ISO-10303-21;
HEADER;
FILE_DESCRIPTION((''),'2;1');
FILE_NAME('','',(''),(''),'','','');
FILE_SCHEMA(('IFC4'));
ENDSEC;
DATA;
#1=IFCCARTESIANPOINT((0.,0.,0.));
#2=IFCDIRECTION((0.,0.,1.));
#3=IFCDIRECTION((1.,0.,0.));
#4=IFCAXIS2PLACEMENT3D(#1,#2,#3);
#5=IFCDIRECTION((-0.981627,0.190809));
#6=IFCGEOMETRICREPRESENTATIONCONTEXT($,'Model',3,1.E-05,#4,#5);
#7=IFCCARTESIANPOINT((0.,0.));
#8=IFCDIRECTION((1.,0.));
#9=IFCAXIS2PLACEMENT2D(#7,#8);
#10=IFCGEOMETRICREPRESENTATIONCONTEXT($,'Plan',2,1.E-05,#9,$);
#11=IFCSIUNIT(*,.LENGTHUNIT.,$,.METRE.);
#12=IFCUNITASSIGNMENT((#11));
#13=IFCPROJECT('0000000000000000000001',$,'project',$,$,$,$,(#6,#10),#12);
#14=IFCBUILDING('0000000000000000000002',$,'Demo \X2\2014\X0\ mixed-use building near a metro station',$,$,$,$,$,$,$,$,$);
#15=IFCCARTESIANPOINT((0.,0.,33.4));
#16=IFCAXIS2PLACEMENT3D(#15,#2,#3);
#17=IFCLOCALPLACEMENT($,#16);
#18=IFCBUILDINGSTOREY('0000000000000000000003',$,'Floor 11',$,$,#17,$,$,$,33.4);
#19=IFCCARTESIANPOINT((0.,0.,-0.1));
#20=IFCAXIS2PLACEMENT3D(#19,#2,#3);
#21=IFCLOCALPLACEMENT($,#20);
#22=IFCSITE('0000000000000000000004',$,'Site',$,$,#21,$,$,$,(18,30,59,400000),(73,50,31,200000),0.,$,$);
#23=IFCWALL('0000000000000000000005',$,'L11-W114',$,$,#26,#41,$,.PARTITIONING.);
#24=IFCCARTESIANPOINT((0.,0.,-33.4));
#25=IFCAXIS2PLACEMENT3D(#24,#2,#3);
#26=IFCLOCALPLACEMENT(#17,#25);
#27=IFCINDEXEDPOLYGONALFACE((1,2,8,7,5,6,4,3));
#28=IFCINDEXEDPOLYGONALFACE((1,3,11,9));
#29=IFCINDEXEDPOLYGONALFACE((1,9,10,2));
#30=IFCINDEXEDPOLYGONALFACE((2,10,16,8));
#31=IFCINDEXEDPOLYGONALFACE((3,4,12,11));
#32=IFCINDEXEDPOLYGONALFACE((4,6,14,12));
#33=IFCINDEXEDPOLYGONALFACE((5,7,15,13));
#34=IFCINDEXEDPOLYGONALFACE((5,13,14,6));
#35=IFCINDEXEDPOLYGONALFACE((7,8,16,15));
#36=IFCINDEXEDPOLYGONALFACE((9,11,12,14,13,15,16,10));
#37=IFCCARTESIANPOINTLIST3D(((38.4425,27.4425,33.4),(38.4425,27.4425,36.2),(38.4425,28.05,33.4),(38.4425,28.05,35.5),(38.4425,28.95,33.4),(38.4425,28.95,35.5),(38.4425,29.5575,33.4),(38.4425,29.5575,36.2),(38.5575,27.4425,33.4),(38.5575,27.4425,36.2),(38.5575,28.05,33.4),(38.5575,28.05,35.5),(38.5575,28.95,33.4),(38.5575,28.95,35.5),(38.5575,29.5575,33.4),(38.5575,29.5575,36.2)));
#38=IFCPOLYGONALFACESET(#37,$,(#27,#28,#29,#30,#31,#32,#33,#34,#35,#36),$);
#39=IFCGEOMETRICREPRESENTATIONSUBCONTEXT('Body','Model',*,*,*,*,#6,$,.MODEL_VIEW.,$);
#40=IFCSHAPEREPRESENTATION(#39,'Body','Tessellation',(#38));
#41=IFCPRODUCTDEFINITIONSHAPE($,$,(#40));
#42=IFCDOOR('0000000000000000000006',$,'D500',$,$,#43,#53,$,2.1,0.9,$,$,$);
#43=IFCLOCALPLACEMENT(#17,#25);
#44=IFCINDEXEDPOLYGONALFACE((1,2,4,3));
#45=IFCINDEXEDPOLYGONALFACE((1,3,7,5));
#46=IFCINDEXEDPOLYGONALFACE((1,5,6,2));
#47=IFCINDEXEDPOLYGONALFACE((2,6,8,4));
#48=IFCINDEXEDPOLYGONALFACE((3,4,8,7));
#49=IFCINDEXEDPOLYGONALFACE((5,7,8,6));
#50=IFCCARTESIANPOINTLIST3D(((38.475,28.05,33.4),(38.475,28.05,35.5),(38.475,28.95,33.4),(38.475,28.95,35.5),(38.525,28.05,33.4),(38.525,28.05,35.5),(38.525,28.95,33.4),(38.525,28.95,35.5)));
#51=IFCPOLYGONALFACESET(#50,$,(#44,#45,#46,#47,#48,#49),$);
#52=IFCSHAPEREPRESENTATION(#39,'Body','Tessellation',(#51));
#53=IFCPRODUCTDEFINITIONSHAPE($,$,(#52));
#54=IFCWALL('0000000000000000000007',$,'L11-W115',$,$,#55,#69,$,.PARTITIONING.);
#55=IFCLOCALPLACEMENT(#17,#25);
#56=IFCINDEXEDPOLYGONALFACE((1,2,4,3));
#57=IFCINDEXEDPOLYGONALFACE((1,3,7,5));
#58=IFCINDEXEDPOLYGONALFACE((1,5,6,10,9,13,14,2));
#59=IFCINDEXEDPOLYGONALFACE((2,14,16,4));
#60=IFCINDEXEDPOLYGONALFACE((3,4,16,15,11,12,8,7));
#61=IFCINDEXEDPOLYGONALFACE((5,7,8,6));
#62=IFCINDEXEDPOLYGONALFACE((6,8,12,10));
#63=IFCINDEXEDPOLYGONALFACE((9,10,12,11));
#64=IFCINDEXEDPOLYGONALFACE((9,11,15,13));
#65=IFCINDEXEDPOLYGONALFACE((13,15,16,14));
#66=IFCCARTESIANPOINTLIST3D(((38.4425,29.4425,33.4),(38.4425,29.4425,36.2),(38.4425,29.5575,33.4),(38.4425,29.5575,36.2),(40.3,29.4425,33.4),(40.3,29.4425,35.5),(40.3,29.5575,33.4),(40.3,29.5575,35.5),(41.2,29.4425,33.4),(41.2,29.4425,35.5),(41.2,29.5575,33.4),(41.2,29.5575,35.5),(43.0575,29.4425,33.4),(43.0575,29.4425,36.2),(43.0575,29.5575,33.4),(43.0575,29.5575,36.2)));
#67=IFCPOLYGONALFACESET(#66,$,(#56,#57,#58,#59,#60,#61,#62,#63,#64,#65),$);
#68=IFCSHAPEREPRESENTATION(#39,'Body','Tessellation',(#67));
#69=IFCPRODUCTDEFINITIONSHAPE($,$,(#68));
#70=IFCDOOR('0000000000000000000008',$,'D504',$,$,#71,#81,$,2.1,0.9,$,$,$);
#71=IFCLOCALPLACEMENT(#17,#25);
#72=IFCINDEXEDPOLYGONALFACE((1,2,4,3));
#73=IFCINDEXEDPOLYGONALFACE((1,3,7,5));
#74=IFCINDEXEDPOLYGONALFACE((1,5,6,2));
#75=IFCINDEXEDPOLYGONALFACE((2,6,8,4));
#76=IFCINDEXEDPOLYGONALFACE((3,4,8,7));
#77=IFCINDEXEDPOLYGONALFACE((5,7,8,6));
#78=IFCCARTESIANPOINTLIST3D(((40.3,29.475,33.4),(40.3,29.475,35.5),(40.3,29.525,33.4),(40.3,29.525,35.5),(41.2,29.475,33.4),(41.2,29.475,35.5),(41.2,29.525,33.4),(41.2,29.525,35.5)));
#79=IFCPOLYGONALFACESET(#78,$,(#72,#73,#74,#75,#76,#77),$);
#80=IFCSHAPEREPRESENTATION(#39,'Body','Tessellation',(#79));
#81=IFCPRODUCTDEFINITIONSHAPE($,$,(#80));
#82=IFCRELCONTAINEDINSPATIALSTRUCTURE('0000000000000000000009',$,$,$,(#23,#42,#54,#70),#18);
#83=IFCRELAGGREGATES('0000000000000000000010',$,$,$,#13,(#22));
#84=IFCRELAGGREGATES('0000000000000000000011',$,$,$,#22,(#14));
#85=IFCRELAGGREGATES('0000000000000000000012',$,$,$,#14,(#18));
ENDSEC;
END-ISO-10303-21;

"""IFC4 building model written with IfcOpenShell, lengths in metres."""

from ifc_helpers import new_model, si_unit, direction, frame, origin_with_axes, origin_2d_with_axis, place, context, subcontext, project, spatial, line, indexed_curve, outline, extrude, element, fill, save


model = new_model("IFC4")

# Units and contexts
model_context = context("Model", 3, precision=1e-05, world=origin_with_axes(), true_north=direction((-0.981627, 0.190809)))
plan_context = context("Plan", 2, precision=1e-05, world=origin_2d_with_axis())
body_context = subcontext(model_context, "Body", "Model", "MODEL_VIEW")
ifc_project = project(units=[si_unit("LENGTHUNIT", "METRE")], contexts=[model_context, plan_context])

# Site, building, storey
site_placement = place(None, frame((0.0, 0.0, -0.1), z_axis=(0.0, 0.0, 1.0), x_axis=(1.0, 0.0, 0.0)))
site = spatial("IfcSite", under=ifc_project, at=site_placement, Name="Site", RefLatitude=(18, 30, 59, 400000), RefLongitude=(73, 50, 31, 200000), RefElevation=0.0)
building = spatial("IfcBuilding", under=site, Name="Demo — mixed-use building near a metro station")
storey_placement = place(None, frame((0.0, 0.0, 33.4), z_axis=(0.0, 0.0, 1.0), x_axis=(1.0, 0.0, 0.0)))
storey = spatial("IfcBuildingStorey", under=building, at=storey_placement, Name="Floor 11", Elevation=33.4)

# Walls, openings, doors
wall_1_placement = place(storey_placement, frame((0.0, 0.0, -33.4), z_axis=(0.0, 0.0, 1.0), x_axis=(1.0, 0.0, 0.0)))
wall_1 = element("IfcWall", 1, at=wall_1_placement, inside=storey, Name="L11-W114", PredefinedType="PARTITIONING", context=body_context, shape_type="SweptSolid", body=[
    extrude(outline(indexed_curve([(38.5575, 29.5575), (38.5575, 27.4425), (38.4425, 27.4425), (38.4425, 29.5575)], segments=[line(1, 2, 3, 4, 1)])), frame((0.0, 0.0, 33.4), z_axis=(0.0, 0.0, 1.0), x_axis=(1.0, 0.0, 0.0)), (0.0, 0.0, 1.0), 2.8),
])
opening_1_placement = place(wall_1_placement, origin_with_axes())
opening_1 = element("IfcOpeningElement", 2, at=opening_1_placement, cuts=wall_1, context=body_context, shape_type="SweptSolid", body=[
    extrude(outline(indexed_curve([(38.6075, 28.95), (38.6075, 28.05), (38.3925, 28.05), (38.3925, 28.95)], segments=[line(1, 2, 3, 4, 1)])), frame((0.0, 0.0, 33.4), z_axis=(0.0, 0.0, 1.0), x_axis=(1.0, 0.0, 0.0)), (0.0, 0.0, 1.0), 2.1),
])
door_1_placement = place(storey_placement, frame((0.0, 0.0, -33.4), z_axis=(0.0, 0.0, 1.0), x_axis=(1.0, 0.0, 0.0)))
door_1 = element("IfcDoor", 3, at=door_1_placement, inside=storey, Name="D500", OverallHeight=2.1, OverallWidth=0.9, context=body_context, shape_type="SweptSolid", body=[
    extrude(outline(indexed_curve([(38.525, 28.95), (38.525, 28.05), (38.475, 28.05), (38.475, 28.95)], segments=[line(1, 2, 3, 4, 1)])), frame((0.0, 0.0, 33.4), z_axis=(0.0, 0.0, 1.0), x_axis=(1.0, 0.0, 0.0)), (0.0, 0.0, 1.0), 2.1),
])
fill(opening_1, door_1)
wall_2_placement = place(storey_placement, frame((0.0, 0.0, -33.4), z_axis=(0.0, 0.0, 1.0), x_axis=(1.0, 0.0, 0.0)))
wall_2 = element("IfcWall", 4, at=wall_2_placement, inside=storey, Name="L11-W115", PredefinedType="PARTITIONING", context=body_context, shape_type="SweptSolid", body=[
    extrude(outline(indexed_curve([(43.0575, 29.4425), (38.4425, 29.4425), (38.4425, 29.5575), (43.0575, 29.5575)], segments=[line(1, 2, 3, 4, 1)])), frame((0.0, 0.0, 33.4), z_axis=(0.0, 0.0, 1.0), x_axis=(1.0, 0.0, 0.0)), (0.0, 0.0, 1.0), 2.8),
])
opening_2_placement = place(wall_2_placement, origin_with_axes())
opening_2 = element("IfcOpeningElement", 5, at=opening_2_placement, cuts=wall_2, context=body_context, shape_type="SweptSolid", body=[
    extrude(outline(indexed_curve([(41.2, 29.3925), (40.3, 29.3925), (40.3, 29.6075), (41.2, 29.6075)], segments=[line(1, 2, 3, 4, 1)])), frame((0.0, 0.0, 33.4), z_axis=(0.0, 0.0, 1.0), x_axis=(1.0, 0.0, 0.0)), (0.0, 0.0, 1.0), 2.1),
])
door_2_placement = place(storey_placement, frame((0.0, 0.0, -33.4), z_axis=(0.0, 0.0, 1.0), x_axis=(1.0, 0.0, 0.0)))
door_2 = element("IfcDoor", 6, at=door_2_placement, inside=storey, Name="D504", OverallHeight=2.1, OverallWidth=0.9, context=body_context, shape_type="SweptSolid", body=[
    extrude(outline(indexed_curve([(41.2, 29.475), (40.3, 29.475), (40.3, 29.525), (41.2, 29.525)], segments=[line(1, 2, 3, 4, 1)])), frame((0.0, 0.0, 33.4), z_axis=(0.0, 0.0, 1.0), x_axis=(1.0, 0.0, 0.0)), (0.0, 0.0, 1.0), 2.1),
])
fill(opening_2, door_2)

save(model, "model.ifc")
